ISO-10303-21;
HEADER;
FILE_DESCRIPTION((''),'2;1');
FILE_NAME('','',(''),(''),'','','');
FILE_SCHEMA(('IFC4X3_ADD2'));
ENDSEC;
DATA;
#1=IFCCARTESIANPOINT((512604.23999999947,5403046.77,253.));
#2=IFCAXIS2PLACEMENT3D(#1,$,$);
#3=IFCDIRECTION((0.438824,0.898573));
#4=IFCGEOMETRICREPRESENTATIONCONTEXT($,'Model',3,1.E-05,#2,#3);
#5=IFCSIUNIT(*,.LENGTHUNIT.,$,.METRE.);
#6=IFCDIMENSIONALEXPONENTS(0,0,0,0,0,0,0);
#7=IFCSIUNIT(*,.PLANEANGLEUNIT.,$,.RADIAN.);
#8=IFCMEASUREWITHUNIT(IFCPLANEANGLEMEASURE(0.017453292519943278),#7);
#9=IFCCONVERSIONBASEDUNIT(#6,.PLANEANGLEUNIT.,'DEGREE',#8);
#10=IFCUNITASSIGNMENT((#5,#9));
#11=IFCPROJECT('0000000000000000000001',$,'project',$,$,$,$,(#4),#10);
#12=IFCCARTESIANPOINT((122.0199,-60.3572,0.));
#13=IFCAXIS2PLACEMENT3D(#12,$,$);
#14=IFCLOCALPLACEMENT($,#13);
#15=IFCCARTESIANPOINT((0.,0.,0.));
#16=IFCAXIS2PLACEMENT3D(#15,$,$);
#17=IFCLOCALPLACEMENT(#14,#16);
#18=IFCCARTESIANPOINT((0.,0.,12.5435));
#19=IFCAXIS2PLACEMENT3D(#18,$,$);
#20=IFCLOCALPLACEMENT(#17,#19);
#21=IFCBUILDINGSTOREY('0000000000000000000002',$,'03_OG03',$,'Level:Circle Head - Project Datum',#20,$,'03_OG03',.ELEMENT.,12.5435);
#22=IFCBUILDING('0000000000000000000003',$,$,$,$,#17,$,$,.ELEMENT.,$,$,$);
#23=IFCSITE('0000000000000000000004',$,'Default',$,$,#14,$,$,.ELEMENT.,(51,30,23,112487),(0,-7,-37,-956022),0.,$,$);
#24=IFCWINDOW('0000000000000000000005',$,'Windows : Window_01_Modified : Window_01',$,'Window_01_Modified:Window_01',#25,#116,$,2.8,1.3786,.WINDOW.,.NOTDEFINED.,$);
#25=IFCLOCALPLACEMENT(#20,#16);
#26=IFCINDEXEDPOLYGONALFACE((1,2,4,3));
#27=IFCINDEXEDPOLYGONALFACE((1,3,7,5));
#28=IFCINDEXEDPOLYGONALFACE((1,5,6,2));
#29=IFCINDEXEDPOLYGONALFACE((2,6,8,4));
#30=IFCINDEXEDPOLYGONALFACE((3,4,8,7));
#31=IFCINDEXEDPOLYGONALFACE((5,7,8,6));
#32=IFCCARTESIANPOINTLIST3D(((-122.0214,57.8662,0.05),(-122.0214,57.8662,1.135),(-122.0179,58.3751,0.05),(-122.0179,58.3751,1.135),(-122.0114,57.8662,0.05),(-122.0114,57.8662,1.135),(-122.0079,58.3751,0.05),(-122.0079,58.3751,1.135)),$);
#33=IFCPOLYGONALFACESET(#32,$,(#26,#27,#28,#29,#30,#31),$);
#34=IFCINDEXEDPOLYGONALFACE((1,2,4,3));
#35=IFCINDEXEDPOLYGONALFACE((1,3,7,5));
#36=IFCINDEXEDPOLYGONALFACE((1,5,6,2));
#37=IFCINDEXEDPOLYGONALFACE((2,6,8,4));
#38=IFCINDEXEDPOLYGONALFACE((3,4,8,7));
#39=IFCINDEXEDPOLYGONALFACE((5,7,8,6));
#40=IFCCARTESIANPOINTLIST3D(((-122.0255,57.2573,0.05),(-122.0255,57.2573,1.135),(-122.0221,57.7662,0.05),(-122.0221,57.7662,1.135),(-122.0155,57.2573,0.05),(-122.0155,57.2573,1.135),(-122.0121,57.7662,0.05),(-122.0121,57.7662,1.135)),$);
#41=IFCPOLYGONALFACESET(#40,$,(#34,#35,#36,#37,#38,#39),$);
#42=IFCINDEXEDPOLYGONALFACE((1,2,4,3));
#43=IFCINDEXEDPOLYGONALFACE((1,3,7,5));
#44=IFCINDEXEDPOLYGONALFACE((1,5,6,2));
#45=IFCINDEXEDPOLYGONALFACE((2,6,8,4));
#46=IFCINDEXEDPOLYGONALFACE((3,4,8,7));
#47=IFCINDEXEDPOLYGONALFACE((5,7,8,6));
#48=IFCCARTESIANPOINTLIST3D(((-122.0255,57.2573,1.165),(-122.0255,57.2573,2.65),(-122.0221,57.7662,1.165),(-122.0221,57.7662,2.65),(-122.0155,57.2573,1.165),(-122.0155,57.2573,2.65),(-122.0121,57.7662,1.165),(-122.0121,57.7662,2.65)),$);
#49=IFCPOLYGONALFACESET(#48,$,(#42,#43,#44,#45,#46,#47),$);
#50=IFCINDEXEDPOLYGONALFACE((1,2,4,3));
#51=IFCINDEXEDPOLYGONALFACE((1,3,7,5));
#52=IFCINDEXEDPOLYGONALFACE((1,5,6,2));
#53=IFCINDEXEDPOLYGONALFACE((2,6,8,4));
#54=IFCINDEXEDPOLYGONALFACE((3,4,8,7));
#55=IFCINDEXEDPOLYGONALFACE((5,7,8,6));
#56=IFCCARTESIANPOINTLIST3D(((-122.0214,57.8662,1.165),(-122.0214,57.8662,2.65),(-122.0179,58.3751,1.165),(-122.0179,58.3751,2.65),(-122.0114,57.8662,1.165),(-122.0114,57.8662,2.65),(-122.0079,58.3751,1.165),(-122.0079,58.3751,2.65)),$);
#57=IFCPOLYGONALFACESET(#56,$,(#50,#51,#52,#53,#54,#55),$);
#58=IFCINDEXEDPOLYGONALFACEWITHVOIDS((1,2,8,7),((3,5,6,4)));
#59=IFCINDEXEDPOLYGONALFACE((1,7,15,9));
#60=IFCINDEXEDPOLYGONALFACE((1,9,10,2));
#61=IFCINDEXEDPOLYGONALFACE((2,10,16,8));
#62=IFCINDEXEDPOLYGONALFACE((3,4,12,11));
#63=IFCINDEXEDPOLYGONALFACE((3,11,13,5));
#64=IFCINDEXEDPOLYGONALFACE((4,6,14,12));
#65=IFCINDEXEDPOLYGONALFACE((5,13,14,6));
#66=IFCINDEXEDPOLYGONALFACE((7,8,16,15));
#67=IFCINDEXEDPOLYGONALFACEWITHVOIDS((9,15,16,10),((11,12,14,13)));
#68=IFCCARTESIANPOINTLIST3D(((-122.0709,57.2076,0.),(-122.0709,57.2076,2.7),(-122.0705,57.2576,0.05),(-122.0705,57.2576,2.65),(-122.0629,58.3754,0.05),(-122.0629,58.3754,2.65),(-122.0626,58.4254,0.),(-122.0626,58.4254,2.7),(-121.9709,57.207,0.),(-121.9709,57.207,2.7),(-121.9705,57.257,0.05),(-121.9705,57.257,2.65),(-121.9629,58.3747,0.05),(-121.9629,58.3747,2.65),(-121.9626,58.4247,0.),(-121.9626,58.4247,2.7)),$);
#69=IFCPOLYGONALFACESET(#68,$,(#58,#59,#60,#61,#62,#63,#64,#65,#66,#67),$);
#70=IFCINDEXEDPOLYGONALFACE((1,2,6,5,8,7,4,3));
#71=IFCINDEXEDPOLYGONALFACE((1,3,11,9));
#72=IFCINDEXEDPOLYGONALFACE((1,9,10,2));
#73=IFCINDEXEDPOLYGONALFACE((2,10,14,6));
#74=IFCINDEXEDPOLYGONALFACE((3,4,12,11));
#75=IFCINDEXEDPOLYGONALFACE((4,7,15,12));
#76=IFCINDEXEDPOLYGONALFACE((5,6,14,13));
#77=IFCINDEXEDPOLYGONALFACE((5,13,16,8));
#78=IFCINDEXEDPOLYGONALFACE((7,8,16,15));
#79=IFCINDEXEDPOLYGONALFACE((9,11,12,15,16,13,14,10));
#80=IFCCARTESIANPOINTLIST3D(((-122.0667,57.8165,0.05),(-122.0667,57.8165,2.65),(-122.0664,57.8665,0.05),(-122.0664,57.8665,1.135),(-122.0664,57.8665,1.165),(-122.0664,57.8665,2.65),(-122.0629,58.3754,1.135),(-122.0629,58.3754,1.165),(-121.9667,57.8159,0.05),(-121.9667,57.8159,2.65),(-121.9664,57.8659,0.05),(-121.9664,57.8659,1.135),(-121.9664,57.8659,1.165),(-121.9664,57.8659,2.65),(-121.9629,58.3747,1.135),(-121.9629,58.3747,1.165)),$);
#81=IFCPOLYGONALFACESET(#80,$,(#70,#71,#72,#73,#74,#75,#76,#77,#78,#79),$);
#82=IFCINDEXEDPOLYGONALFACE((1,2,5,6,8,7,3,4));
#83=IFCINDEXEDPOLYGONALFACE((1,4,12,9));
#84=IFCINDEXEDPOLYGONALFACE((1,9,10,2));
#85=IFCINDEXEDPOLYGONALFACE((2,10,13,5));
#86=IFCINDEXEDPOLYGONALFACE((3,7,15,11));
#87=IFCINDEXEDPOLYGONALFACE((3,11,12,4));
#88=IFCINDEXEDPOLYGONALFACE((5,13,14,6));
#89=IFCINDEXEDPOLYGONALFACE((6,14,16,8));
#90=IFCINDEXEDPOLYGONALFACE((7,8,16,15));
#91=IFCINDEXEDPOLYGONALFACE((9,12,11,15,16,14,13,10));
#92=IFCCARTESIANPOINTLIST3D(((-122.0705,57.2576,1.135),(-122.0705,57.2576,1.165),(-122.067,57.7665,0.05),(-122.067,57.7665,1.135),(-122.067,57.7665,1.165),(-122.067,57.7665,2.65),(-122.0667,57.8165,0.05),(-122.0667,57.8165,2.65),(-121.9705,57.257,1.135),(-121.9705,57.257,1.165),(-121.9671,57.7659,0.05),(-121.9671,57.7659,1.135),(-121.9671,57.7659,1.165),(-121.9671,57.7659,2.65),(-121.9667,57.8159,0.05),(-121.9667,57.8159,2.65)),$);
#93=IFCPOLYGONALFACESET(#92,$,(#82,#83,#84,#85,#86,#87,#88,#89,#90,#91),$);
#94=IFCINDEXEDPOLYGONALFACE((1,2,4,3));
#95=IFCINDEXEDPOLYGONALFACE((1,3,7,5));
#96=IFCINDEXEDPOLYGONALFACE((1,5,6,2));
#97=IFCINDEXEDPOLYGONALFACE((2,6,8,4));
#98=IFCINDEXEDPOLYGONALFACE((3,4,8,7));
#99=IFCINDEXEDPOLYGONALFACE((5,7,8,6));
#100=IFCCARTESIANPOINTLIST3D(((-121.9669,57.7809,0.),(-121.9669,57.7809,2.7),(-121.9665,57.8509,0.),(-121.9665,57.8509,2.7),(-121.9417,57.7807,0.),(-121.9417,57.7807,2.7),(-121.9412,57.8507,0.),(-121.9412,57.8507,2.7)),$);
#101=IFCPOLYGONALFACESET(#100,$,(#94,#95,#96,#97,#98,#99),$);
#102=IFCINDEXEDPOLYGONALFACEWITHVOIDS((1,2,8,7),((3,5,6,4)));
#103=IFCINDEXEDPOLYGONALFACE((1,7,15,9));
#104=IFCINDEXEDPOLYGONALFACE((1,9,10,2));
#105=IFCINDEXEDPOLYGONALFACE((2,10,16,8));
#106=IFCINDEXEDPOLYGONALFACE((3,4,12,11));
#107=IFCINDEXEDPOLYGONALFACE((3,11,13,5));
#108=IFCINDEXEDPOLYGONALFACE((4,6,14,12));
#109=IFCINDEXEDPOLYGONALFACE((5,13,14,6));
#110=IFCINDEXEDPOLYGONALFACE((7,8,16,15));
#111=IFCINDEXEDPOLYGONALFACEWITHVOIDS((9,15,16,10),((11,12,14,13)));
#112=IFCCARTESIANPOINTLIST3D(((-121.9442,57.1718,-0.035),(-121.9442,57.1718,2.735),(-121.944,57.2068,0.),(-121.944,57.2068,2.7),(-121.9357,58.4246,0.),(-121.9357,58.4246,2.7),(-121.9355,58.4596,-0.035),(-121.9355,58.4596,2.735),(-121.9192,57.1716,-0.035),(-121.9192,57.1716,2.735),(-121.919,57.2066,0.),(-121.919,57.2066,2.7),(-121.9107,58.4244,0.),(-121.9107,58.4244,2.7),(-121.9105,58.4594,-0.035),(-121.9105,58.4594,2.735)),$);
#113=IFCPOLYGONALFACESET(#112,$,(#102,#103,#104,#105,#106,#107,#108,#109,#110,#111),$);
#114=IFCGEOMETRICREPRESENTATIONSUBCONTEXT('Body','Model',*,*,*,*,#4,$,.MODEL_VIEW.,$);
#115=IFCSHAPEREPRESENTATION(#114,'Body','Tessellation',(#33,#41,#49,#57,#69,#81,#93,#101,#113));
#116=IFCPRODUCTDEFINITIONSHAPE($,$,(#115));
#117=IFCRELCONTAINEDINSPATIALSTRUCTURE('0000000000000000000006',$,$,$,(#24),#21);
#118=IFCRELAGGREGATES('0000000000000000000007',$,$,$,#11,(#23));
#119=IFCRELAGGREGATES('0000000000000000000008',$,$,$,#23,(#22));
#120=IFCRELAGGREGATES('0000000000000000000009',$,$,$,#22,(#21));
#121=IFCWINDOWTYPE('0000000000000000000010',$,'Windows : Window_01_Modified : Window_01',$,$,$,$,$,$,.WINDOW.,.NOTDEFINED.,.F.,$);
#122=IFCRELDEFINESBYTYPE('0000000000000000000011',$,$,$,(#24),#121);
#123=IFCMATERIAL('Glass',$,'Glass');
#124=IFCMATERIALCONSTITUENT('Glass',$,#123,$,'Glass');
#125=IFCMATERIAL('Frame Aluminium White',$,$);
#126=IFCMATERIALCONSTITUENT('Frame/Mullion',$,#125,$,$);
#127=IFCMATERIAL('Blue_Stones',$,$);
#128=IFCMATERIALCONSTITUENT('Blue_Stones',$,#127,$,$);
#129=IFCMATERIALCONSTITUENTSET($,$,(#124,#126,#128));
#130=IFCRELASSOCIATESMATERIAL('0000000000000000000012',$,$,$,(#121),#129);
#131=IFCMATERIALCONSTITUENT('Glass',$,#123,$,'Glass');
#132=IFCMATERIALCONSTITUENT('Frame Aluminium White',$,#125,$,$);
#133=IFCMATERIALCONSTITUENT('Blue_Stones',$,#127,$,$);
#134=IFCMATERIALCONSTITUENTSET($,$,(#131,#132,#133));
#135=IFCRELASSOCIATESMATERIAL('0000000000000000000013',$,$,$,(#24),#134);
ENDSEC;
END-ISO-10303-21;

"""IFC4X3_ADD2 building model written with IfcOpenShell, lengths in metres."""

from ifc_helpers import new_model, entity, si_unit, converted_unit, direction, frame, frame_2d, origin, origin_2d_with_axis, place, context, subcontext, project, spatial, polyline, rectangle, outline, extrude, source, transform, mapped, material, constituent, constituent_set, type_object, type_shapes, element, save


model = new_model("IFC4X3_ADD2")

# Units and contexts
model_context = context("Model", 3, precision=1e-05, world=frame((512604.23999999947, 5403046.77, 253.0)), true_north=direction((0.438824, 0.898573)))
body_context = subcontext(model_context, "Body", "Model", "MODEL_VIEW")
ifc_project = project(units=[si_unit("LENGTHUNIT", "METRE"), converted_unit("PLANEANGLEUNIT", "DEGREE", entity("IfcPlaneAngleMeasure", 0.017453292519943278), si_unit("PLANEANGLEUNIT", "RADIAN"), dimensions=[0, 0, 0, 0, 0, 0, 0])], contexts=[model_context])

# Site, building, storey
site_placement = place(None, frame((122.0199, -60.3572, 0.0)))
site = spatial("IfcSite", under=ifc_project, at=site_placement, Name="Default", CompositionType="ELEMENT", RefLatitude=(51, 30, 23, 112487), RefLongitude=(0, -7, -37, -956022), RefElevation=0.0)
building_placement = place(site_placement, origin())
building = spatial("IfcBuilding", under=site, at=building_placement, CompositionType="ELEMENT")
storey_placement = place(building_placement, frame((0.0, 0.0, 12.5435)))
storey = spatial("IfcBuildingStorey", under=building, at=storey_placement, Name="03_OG03", ObjectType="Level:Circle Head - Project Datum", LongName="03_OG03", CompositionType="ELEMENT", Elevation=12.5435)

# Shared definitions
ifc_material_1 = material(Name="Glass", Category="Glass")
ifc_material_2 = material(Name="Frame Aluminium White")
ifc_material_3 = material(Name="Blue_Stones")

# Window
ifc_constituent_1 = constituent(ifc_material_1, Name="Glass", Category="Glass")
ifc_constituent_2 = constituent(ifc_material_2, Name="Frame Aluminium White")
ifc_constituent_3 = constituent(ifc_material_3, Name="Blue_Stones")
ifc_constituent_set_1 = constituent_set(constituents=[ifc_constituent_1, ifc_constituent_2, ifc_constituent_3])
ifc_constituent_4 = constituent(ifc_material_1, Name="Glass", Category="Glass")
ifc_constituent_5 = constituent(ifc_material_2, Name="Frame/Mullion")
ifc_constituent_6 = constituent(ifc_material_3, Name="Blue_Stones")
ifc_constituent_set_2 = constituent_set(constituents=[ifc_constituent_4, ifc_constituent_5, ifc_constituent_6])
window_type_1 = type_object("IfcWindowType", Name="Windows : Window_01_Modified : Window_01", ParameterTakesPrecedence=False, PartitioningType="NOTDEFINED", PredefinedType="WINDOW", material=ifc_constituent_set_2)
shared_shape_1 = source(origin(), body_context, "Body", "SweptSolid", [
    extrude(rectangle(XDim=0.5089, YDim=0.01, at=origin_2d_with_axis()), frame((0.3845, -0.0769, 0.1), z_axis=(0.0, 0.0, 1.0), x_axis=(-1.0, 0.0, 0.0)), (0.0, 0.0, 1.0), 1.085),
    extrude(rectangle(XDim=0.01, YDim=0.5089, at=frame_2d((0.0, 0.0), x_axis=(1.0, 0.0))), frame((0.9934, -0.0769, 0.1), z_axis=(0.0, 0.0, 1.0), x_axis=(0.0, 1.0, 0.0)), (0.0, 0.0, 1.0), 1.085),
    extrude(rectangle(XDim=0.5089, YDim=0.01, at=origin_2d_with_axis()), frame((0.9934, -0.0769, 1.215), z_axis=(0.0, 0.0, 1.0), x_axis=(-1.0, 0.0, 0.0)), (0.0, 0.0, 1.0), 1.485),
    extrude(rectangle(XDim=0.5089, YDim=0.01, at=frame_2d((0.0, 0.0), x_axis=(1.0, 0.0))), frame((0.3845, -0.0769, 1.215), z_axis=(0.0, 0.0, 1.0), x_axis=(-1.0, 0.0, 0.0)), (0.0, 0.0, 1.0), 1.485),
    extrude(outline(polyline([(-1.35, -0.6089), (1.35, -0.6089), (1.35, 0.6089), (-1.35, 0.6089), (-1.35, -0.6089)]), holes=[polyline([(1.3, 0.5589), (1.3, -0.5589), (-1.3, -0.5589), (-1.3, 0.5589), (1.3, 0.5589)])]), frame((0.689, -0.1269, 1.4), z_axis=(0.0, 1.0, 0.0), x_axis=(0.0, 0.0, 1.0)), (0.0, 0.0, 1.0), 0.1),
    extrude(outline(polyline([(-0.085, 0.1147), (1.4, 0.1147), (1.4, 0.1647), (-1.2, 0.1647), (-1.2, 0.1147), (-0.115, 0.1147), (-0.115, -0.3942), (-0.085, -0.3942), (-0.085, 0.1147)])), frame((0.5243, -0.1269, 1.3), z_axis=(0.0, 1.0, 0.0), x_axis=(0.0, 0.0, 1.0)), (0.0, 0.0, 1.0), 0.1),
    extrude(outline(polyline([(-1.4, -0.1147), (-1.4, -0.1647), (1.2, -0.1647), (1.2, -0.1147), (0.115, -0.1147), (0.115, 0.3942), (0.085, 0.3942), (0.085, -0.1147), (-1.4, -0.1147)])), frame((0.8537, -0.1269, 1.3), z_axis=(0.0, -1.0, 0.0), x_axis=(0.0, 0.0, -1.0)), (0.0, 0.0, -1.0), 0.1),
    extrude(rectangle(XDim=0.0253, YDim=0.07, at=frame_2d((0.0, 0.0), x_axis=(1.0, 0.0))), frame((0.689, -0.0142, 0.05), z_axis=(0.0, 0.0, 1.0), x_axis=(0.0, -1.0, 0.0)), (0.0, 0.0, 1.0), 2.7),
    extrude(outline(polyline([(-0.6439, -1.385), (0.6439, -1.385), (0.6439, 1.385), (-0.6439, 1.385), (-0.6439, -1.385)]), holes=[polyline([(-0.6089, -1.35), (-0.6089, 1.35), (0.6089, 1.35), (0.6089, -1.35), (-0.6089, -1.35)])]), frame((0.689, 0.0, 1.4), z_axis=(0.0, 1.0, 0.0), x_axis=(1.0, 0.0, 0.0)), (0.0, 0.0, 1.0), 0.025),
])
type_shapes(window_type_1, [shared_shape_1])
window_1_placement = place(storey_placement, frame((-121.9352, 58.5046, -0.05), z_axis=(0.0, 0.0, 1.0), x_axis=(-0.0068, -0.999977, 0.0)))
element("IfcWindow", 1, at=window_1_placement, inside=storey, type_object=window_type_1, material=ifc_constituent_set_1, Name="Windows : Window_01_Modified : Window_01", ObjectType="Window_01_Modified:Window_01", OverallHeight=2.8, OverallWidth=1.3786, PartitioningType="NOTDEFINED", PredefinedType="WINDOW", context=body_context, shape_type="MappedRepresentation", body=[
    mapped(shared_shape_1, transform((0.0, 0.0, 0.0), scale=1.0)),
])

save(model, "model.ifc")
